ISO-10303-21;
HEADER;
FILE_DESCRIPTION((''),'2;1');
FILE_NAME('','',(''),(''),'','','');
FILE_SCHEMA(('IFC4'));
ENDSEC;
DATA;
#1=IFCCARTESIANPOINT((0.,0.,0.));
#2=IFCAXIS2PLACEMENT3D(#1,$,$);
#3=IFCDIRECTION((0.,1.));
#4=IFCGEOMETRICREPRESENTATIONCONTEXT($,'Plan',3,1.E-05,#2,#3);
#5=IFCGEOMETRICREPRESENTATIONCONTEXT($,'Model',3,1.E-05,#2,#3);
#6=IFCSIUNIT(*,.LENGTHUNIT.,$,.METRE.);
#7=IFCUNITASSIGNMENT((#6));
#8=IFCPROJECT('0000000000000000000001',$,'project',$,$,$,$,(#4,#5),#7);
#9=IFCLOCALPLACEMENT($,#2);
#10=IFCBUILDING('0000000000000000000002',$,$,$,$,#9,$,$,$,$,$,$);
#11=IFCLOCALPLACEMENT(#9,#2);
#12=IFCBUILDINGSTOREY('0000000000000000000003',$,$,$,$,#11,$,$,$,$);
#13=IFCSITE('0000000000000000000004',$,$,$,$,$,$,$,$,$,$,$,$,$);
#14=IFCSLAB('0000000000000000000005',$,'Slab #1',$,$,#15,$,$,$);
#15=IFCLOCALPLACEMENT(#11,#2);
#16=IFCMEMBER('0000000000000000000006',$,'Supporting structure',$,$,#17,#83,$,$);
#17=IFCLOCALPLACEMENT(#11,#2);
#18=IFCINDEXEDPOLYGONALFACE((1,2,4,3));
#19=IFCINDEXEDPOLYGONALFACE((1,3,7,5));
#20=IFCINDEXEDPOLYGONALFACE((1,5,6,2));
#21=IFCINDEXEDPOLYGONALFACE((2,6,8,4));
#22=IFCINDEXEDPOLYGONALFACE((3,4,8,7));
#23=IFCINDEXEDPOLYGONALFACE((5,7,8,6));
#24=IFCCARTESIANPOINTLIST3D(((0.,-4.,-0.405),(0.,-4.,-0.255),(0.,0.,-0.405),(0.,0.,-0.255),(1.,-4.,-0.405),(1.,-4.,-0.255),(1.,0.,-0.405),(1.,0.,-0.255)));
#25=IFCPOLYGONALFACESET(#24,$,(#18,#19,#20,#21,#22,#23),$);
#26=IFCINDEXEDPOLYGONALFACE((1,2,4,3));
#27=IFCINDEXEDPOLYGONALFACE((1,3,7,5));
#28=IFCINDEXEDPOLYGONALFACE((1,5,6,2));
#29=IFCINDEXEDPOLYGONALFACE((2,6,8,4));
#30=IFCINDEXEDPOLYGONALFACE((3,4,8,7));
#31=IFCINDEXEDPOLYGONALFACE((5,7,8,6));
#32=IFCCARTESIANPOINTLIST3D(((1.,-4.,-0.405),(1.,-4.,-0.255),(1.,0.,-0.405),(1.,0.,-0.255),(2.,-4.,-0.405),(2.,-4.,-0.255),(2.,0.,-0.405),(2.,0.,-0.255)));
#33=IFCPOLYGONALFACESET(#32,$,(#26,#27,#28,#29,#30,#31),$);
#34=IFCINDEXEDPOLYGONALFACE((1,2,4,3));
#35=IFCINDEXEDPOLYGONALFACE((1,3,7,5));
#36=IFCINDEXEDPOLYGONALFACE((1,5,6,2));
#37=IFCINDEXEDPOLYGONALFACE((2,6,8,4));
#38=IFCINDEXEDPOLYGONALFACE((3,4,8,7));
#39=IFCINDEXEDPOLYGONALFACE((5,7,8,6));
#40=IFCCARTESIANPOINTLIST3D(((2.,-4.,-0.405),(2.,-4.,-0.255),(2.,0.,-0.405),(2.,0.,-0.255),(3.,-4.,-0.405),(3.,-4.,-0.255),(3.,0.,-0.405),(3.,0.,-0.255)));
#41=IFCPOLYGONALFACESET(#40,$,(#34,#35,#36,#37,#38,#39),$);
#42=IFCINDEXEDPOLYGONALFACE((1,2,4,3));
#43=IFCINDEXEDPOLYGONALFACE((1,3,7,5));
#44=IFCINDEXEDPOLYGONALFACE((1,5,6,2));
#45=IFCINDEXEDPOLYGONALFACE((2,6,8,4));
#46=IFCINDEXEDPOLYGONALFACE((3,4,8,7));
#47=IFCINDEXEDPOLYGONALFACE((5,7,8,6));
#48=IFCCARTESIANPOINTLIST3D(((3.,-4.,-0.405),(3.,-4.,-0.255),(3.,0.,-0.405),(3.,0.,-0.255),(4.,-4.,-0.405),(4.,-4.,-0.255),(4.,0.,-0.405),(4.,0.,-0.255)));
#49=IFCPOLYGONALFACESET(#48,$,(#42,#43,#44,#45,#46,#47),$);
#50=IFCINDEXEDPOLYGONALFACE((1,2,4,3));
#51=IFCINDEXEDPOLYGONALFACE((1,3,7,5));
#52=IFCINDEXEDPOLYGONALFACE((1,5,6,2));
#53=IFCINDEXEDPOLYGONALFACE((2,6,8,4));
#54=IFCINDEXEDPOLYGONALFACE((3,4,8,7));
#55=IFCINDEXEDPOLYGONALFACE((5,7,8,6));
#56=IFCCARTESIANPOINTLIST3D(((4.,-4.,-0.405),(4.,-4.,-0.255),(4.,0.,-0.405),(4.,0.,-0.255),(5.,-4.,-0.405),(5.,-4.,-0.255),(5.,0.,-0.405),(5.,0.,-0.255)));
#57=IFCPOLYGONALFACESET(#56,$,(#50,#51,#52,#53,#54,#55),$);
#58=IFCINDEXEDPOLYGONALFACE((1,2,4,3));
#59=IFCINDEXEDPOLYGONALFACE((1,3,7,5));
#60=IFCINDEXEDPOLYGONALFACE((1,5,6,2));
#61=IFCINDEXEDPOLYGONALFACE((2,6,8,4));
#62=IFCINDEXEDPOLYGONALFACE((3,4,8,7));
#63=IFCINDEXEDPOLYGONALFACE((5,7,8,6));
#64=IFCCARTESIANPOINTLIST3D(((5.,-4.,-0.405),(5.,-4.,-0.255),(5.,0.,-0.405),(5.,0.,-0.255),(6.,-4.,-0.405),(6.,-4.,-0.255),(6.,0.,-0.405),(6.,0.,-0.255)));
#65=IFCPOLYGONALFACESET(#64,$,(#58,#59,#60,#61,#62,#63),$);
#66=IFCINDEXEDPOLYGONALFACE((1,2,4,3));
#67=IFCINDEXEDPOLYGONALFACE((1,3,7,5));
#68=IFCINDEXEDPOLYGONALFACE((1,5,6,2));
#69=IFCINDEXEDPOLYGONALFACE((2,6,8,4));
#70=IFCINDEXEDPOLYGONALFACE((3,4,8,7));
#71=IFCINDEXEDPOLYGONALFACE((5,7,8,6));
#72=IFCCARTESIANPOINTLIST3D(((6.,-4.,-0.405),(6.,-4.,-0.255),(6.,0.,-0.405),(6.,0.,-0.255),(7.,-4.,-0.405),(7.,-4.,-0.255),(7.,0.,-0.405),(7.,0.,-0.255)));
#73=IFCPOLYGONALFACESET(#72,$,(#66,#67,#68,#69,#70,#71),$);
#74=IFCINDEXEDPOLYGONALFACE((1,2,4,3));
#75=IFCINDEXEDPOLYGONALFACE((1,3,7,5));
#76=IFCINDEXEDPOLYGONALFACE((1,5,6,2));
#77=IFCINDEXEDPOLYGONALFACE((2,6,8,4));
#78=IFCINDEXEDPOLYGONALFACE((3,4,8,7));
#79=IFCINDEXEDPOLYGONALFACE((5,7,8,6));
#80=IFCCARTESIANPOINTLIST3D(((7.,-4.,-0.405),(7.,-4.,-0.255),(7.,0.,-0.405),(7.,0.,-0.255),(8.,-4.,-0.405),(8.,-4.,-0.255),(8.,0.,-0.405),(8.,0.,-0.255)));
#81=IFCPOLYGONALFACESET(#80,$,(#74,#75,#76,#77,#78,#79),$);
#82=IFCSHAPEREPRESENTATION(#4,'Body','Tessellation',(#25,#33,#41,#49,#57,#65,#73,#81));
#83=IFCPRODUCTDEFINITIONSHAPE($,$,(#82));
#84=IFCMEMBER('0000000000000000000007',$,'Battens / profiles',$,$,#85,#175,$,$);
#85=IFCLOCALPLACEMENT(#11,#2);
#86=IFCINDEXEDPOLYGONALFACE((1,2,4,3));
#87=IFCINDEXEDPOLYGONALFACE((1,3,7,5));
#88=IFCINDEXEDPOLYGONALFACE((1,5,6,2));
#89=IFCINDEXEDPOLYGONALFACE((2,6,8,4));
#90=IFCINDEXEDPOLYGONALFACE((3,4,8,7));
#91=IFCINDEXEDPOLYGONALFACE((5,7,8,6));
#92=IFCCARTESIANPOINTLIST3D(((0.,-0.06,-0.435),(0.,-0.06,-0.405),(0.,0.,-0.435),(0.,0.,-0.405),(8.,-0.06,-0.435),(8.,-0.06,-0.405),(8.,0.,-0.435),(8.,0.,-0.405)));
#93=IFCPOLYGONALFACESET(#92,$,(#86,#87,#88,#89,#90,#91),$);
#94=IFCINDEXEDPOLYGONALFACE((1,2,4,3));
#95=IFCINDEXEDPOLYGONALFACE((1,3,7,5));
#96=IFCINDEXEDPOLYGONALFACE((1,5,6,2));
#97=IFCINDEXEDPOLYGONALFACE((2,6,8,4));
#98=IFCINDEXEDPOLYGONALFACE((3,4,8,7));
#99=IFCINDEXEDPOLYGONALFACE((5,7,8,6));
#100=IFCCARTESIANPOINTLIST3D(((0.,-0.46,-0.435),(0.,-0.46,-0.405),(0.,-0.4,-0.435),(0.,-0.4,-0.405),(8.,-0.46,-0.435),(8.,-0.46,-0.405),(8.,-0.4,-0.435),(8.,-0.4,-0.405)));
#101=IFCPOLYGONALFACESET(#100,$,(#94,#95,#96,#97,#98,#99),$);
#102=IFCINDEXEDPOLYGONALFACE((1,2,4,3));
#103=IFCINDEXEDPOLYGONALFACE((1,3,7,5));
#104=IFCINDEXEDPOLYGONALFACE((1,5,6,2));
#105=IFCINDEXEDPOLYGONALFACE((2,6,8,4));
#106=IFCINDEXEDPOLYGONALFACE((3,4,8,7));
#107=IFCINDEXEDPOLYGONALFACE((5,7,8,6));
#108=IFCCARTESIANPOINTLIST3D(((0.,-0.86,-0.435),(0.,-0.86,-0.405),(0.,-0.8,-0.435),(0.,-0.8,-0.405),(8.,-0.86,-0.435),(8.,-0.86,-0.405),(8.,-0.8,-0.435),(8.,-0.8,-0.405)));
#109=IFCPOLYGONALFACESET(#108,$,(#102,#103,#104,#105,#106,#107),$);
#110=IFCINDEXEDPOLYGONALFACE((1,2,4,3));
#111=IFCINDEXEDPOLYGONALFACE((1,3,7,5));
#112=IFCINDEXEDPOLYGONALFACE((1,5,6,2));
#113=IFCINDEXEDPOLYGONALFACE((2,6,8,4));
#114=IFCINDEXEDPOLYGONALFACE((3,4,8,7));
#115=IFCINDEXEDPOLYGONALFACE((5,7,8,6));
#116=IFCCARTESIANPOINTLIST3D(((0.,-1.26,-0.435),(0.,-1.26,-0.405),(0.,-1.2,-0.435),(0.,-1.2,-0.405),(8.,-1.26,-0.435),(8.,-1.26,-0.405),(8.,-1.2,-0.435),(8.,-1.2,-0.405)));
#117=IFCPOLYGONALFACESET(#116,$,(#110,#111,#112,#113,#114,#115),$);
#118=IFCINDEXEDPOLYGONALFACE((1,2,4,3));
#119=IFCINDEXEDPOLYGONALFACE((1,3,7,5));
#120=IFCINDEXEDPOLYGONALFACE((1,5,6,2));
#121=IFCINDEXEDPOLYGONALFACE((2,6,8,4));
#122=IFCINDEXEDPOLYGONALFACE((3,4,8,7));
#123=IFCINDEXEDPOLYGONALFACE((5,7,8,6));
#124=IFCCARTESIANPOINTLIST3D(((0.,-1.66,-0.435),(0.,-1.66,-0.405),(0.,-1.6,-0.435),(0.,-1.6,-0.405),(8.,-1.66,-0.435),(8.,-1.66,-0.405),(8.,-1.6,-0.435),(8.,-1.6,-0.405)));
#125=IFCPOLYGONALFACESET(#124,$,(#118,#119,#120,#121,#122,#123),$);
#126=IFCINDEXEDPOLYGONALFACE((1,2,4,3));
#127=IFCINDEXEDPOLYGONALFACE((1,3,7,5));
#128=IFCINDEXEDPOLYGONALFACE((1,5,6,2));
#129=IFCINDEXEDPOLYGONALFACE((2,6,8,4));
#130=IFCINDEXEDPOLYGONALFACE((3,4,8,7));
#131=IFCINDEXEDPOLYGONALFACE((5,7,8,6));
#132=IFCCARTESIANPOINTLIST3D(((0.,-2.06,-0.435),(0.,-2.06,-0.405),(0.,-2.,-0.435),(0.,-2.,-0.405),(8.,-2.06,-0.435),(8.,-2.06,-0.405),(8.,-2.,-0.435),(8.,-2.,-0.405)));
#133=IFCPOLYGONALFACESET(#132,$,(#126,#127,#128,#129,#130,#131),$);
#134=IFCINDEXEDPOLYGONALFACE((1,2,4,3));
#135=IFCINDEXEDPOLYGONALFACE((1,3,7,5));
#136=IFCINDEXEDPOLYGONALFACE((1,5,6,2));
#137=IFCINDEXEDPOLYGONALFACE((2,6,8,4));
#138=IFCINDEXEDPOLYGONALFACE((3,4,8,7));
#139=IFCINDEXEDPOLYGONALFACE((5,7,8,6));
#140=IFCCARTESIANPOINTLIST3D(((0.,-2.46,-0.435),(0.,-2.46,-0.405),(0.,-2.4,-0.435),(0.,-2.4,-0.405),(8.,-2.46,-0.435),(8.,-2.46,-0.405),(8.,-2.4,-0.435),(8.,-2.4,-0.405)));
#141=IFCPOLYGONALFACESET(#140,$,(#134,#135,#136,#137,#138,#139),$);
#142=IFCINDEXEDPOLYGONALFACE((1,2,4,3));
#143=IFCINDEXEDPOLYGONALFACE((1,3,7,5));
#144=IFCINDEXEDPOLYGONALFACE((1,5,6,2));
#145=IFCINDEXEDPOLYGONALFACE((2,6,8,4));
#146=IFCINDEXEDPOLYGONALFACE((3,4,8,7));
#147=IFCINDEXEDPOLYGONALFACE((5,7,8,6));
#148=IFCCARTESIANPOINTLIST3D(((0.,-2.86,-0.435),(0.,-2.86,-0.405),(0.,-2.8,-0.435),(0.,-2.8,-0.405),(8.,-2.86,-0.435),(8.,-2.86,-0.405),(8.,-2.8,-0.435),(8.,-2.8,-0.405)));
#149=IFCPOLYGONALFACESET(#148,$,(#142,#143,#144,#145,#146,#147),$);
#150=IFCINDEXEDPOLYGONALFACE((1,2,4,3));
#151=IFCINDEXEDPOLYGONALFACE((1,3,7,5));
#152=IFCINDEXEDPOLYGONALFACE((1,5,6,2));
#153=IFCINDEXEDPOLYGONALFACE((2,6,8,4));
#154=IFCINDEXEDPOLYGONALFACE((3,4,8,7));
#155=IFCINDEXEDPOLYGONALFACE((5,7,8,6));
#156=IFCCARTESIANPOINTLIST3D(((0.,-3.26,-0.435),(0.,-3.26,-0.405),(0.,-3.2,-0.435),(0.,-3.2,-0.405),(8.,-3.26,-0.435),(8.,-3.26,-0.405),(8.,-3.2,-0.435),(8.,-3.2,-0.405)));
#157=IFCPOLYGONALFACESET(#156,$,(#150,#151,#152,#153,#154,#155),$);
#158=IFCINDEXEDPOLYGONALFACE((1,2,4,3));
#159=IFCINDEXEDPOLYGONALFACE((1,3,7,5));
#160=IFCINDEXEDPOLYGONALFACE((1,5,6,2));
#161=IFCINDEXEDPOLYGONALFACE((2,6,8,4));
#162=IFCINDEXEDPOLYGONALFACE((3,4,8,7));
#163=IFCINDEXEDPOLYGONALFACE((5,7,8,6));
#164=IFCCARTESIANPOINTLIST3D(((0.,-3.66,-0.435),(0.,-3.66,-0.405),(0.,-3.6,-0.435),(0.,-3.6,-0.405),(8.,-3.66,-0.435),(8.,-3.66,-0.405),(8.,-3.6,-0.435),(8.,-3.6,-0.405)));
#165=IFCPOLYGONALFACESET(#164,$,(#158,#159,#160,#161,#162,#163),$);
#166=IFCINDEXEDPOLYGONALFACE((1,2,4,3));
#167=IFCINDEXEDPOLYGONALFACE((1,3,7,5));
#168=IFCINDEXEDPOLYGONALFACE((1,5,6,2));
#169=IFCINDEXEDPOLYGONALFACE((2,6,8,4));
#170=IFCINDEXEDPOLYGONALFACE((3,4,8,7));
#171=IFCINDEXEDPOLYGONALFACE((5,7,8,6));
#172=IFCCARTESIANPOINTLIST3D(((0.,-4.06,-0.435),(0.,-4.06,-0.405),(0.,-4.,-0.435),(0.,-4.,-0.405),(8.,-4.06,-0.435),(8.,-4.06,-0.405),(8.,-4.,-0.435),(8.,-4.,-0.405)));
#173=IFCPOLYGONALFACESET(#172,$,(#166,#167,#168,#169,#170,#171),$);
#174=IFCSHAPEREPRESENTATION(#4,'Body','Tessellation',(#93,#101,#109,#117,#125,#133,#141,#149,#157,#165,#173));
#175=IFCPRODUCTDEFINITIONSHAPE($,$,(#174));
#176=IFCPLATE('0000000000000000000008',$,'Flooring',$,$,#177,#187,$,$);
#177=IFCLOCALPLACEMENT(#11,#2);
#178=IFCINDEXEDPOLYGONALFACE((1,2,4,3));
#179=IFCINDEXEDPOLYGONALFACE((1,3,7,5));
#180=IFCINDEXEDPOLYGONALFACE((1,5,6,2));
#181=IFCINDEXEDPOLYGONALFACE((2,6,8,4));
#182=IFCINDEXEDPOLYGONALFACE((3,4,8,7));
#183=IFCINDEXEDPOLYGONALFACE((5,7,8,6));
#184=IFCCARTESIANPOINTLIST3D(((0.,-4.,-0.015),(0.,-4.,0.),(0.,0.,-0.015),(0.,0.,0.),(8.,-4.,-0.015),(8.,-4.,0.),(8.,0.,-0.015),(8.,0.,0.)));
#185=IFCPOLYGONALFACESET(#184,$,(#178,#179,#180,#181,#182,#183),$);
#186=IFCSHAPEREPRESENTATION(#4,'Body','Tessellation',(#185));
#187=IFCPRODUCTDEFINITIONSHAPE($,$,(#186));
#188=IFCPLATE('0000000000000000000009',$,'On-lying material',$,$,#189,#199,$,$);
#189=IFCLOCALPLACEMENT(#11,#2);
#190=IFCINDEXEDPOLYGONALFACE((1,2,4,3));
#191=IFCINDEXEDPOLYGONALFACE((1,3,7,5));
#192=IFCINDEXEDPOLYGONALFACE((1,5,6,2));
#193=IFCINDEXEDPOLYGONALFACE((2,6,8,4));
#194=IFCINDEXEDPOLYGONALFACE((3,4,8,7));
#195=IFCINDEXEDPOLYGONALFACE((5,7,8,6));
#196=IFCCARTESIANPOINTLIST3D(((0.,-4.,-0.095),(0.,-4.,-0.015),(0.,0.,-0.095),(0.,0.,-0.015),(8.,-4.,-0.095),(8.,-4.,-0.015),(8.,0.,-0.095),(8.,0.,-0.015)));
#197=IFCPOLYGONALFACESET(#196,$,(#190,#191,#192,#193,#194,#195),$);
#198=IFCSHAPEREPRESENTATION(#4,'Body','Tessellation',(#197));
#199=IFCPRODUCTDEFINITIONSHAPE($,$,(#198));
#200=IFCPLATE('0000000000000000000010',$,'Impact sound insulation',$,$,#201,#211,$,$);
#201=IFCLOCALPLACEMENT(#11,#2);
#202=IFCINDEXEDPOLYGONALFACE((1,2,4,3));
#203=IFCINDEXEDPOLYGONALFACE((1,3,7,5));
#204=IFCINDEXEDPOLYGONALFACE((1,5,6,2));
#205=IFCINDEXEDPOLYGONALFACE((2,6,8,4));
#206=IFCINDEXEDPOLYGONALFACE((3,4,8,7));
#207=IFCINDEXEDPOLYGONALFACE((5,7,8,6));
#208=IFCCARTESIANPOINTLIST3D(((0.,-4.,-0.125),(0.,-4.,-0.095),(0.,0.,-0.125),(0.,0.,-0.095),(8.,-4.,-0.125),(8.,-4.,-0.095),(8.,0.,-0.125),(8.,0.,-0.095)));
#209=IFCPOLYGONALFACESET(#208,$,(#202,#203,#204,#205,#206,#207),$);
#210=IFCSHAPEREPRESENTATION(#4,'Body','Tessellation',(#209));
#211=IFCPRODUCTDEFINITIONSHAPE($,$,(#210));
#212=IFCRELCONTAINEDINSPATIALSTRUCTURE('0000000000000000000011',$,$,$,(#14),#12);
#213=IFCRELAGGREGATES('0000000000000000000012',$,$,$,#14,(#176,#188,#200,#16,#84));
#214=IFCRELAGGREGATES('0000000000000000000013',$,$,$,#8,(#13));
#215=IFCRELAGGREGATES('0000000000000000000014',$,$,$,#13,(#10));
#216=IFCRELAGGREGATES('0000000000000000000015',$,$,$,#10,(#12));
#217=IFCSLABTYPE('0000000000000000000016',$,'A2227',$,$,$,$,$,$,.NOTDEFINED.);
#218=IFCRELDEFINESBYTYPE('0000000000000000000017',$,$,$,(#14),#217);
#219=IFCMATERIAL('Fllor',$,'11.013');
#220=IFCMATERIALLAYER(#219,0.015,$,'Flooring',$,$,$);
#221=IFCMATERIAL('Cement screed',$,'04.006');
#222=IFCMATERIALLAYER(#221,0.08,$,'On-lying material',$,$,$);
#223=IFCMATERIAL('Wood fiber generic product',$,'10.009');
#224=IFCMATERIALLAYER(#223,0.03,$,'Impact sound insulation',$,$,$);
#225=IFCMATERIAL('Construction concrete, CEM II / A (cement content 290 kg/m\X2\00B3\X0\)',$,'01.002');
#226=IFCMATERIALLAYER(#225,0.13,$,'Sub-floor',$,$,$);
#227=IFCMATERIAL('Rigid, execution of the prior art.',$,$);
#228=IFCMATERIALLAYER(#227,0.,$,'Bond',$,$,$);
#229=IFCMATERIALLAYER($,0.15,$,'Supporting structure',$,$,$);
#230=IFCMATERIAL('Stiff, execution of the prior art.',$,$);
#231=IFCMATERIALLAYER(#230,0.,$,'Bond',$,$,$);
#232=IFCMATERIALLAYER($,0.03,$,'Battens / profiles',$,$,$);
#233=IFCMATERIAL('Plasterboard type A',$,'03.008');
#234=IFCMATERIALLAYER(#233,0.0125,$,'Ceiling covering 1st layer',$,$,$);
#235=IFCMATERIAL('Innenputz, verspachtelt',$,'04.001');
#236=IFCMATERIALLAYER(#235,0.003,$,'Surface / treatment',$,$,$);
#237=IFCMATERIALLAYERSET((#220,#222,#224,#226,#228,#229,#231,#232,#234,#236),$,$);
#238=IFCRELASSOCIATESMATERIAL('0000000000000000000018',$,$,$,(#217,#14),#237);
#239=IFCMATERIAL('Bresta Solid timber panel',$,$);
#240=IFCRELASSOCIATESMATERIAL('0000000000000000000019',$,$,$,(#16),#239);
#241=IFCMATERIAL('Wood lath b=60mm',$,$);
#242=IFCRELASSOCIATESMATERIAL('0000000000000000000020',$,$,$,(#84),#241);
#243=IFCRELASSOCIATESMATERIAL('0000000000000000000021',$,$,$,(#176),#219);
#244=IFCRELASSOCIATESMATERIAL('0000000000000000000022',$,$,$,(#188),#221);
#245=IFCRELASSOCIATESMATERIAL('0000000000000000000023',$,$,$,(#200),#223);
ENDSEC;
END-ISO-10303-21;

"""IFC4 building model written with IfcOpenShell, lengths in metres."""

from ifc_helpers import new_model, si_unit, direction, frame, frame_2d, origin, origin_with_axes, place, context, project, spatial, rectangle, extrude, material, layer, layer_set, type_object, element, aggregate, save


model = new_model("IFC4")

# Units and contexts
plan_context = context("Plan", 3, precision=1e-05, world=origin(), true_north=direction((0.0, 1.0)))
model_context = context("Model", 3, precision=1e-05, world=origin(), true_north=direction((0.0, 1.0)))
ifc_project = project(units=[si_unit("LENGTHUNIT", "METRE")], contexts=[plan_context, model_context])

# Site, building, storey
site = spatial("IfcSite", under=ifc_project)
building_placement = place(None, origin())
building = spatial("IfcBuilding", under=site, at=building_placement)
storey_placement = place(building_placement, origin())
storey = spatial("IfcBuildingStorey", under=building, at=storey_placement)

# Slab, members, plates
ifc_material_1 = material(Name="Fllor", Category="11.013")
ifc_layer_1 = layer(ifc_material_1, 0.015, Name="Flooring")
ifc_material_2 = material(Name="Cement screed", Category="04.006")
ifc_layer_2 = layer(ifc_material_2, 0.08, Name="On-lying material")
ifc_material_3 = material(Name="Wood fiber generic product", Category="10.009")
ifc_layer_3 = layer(ifc_material_3, 0.03, Name="Impact sound insulation")
ifc_material_4 = material(Name="Construction concrete, CEM II / A (cement content 290 kg/m³)", Category="01.002")
ifc_layer_4 = layer(ifc_material_4, 0.13, Name="Sub-floor")
ifc_material_5 = material(Name="Rigid, execution of the prior art.")
ifc_layer_5 = layer(ifc_material_5, 0.0, Name="Bond")
ifc_layer_6 = layer(None, 0.15, Name="Supporting structure")
ifc_material_6 = material(Name="Stiff, execution of the prior art.")
ifc_layer_7 = layer(ifc_material_6, 0.0, Name="Bond")
ifc_layer_8 = layer(None, 0.03, Name="Battens / profiles")
ifc_material_7 = material(Name="Plasterboard type A", Category="03.008")
ifc_layer_9 = layer(ifc_material_7, 0.0125, Name="Ceiling covering 1st layer")
ifc_material_8 = material(Name="Innenputz, verspachtelt", Category="04.001")
ifc_layer_10 = layer(ifc_material_8, 0.003, Name="Surface / treatment")
ifc_layer_set = layer_set([ifc_layer_1, ifc_layer_2, ifc_layer_3, ifc_layer_4, ifc_layer_5, ifc_layer_6, ifc_layer_7, ifc_layer_8, ifc_layer_9, ifc_layer_10])
slab_type = type_object("IfcSlabType", Name="A2227", PredefinedType="NOTDEFINED", material=ifc_layer_set)
slab_placement = place(None, frame((0.0, 0.0, 0.0), z_axis=(0.0, 0.0, -1.0), x_axis=(1.0, 0.0, 0.0)))
slab = element("IfcSlab", 1, at=slab_placement, inside=storey, type_object=slab_type, material=ifc_layer_set, Name="Slab #1")
ifc_material_9 = material(Name="Bresta Solid timber panel")
member_1_placement = place(slab_placement, origin())
member_1 = element("IfcMember", 2, at=member_1_placement, material=ifc_material_9, Name="Supporting structure", context=plan_context, shape_type="SweptSolid", body=[
    extrude(rectangle(XDim=1.0, YDim=0.15, at=frame_2d((0.5, 0.075), x_axis=(1.0, 0.0))), frame((0.0, 4.0, 0.255), z_axis=(0.0, -1.0, 0.0), x_axis=(1.0, 0.0, 0.0)), (0.0, 0.0, 1.0), 4.0),
    extrude(rectangle(XDim=1.0, YDim=0.15, at=frame_2d((0.5, 0.075), x_axis=(1.0, 0.0))), frame((1.0, 4.0, 0.255), z_axis=(0.0, -1.0, 0.0), x_axis=(1.0, 0.0, 0.0)), (0.0, 0.0, 1.0), 4.0),
    extrude(rectangle(XDim=1.0, YDim=0.15, at=frame_2d((0.5, 0.075), x_axis=(1.0, 0.0))), frame((2.0, 4.0, 0.255), z_axis=(0.0, -1.0, 0.0), x_axis=(1.0, 0.0, 0.0)), (0.0, 0.0, 1.0), 4.0),
    extrude(rectangle(XDim=1.0, YDim=0.15, at=frame_2d((0.5, 0.075), x_axis=(1.0, 0.0))), frame((3.0, 4.0, 0.255), z_axis=(0.0, -1.0, 0.0), x_axis=(1.0, 0.0, 0.0)), (0.0, 0.0, 1.0), 4.0),
    extrude(rectangle(XDim=1.0, YDim=0.15, at=frame_2d((0.5, 0.075), x_axis=(1.0, 0.0))), frame((4.0, 4.0, 0.255), z_axis=(0.0, -1.0, 0.0), x_axis=(1.0, 0.0, 0.0)), (0.0, 0.0, 1.0), 4.0),
    extrude(rectangle(XDim=1.0, YDim=0.15, at=frame_2d((0.5, 0.075), x_axis=(1.0, 0.0))), frame((5.0, 4.0, 0.255), z_axis=(0.0, -1.0, 0.0), x_axis=(1.0, 0.0, 0.0)), (0.0, 0.0, 1.0), 4.0),
    extrude(rectangle(XDim=1.0, YDim=0.15, at=frame_2d((0.5, 0.075), x_axis=(1.0, 0.0))), frame((6.0, 4.0, 0.255), z_axis=(0.0, -1.0, 0.0), x_axis=(1.0, 0.0, 0.0)), (0.0, 0.0, 1.0), 4.0),
    extrude(rectangle(XDim=1.0, YDim=0.15, at=frame_2d((0.5, 0.075), x_axis=(1.0, 0.0))), frame((7.0, 4.0, 0.255), z_axis=(0.0, -1.0, 0.0), x_axis=(1.0, 0.0, 0.0)), (0.0, 0.0, 1.0), 4.0),
])
ifc_material_10 = material(Name="Wood lath b=60mm")
member_2_placement = place(slab_placement, origin())
member_2 = element("IfcMember", 3, at=member_2_placement, material=ifc_material_10, Name="Battens / profiles", context=plan_context, shape_type="SweptSolid", body=[
    extrude(rectangle(XDim=0.06, YDim=0.03, at=frame_2d((0.03, 0.015), x_axis=(1.0, 0.0))), frame((0.0, 0.0, 0.405), z_axis=(1.0, 0.0, 0.0), x_axis=(0.0, 1.0, 0.0)), (0.0, 0.0, 1.0), 8.0),
    extrude(rectangle(XDim=0.06, YDim=0.03, at=frame_2d((0.03, 0.015), x_axis=(1.0, 0.0))), frame((0.0, 0.4, 0.405), z_axis=(1.0, 0.0, 0.0), x_axis=(0.0, 1.0, 0.0)), (0.0, 0.0, 1.0), 8.0),
    extrude(rectangle(XDim=0.06, YDim=0.03, at=frame_2d((0.03, 0.015), x_axis=(1.0, 0.0))), frame((0.0, 0.8, 0.405), z_axis=(1.0, 0.0, 0.0), x_axis=(0.0, 1.0, 0.0)), (0.0, 0.0, 1.0), 8.0),
    extrude(rectangle(XDim=0.06, YDim=0.03, at=frame_2d((0.03, 0.015), x_axis=(1.0, 0.0))), frame((0.0, 1.2, 0.405), z_axis=(1.0, 0.0, 0.0), x_axis=(0.0, 1.0, 0.0)), (0.0, 0.0, 1.0), 8.0),
    extrude(rectangle(XDim=0.06, YDim=0.03, at=frame_2d((0.03, 0.015), x_axis=(1.0, 0.0))), frame((0.0, 1.6, 0.405), z_axis=(1.0, 0.0, 0.0), x_axis=(0.0, 1.0, 0.0)), (0.0, 0.0, 1.0), 8.0),
    extrude(rectangle(XDim=0.06, YDim=0.03, at=frame_2d((0.03, 0.015), x_axis=(1.0, 0.0))), frame((0.0, 2.0, 0.405), z_axis=(1.0, 0.0, 0.0), x_axis=(0.0, 1.0, 0.0)), (0.0, 0.0, 1.0), 8.0),
    extrude(rectangle(XDim=0.06, YDim=0.03, at=frame_2d((0.03, 0.015), x_axis=(1.0, 0.0))), frame((0.0, 2.4, 0.405), z_axis=(1.0, 0.0, 0.0), x_axis=(0.0, 1.0, 0.0)), (0.0, 0.0, 1.0), 8.0),
    extrude(rectangle(XDim=0.06, YDim=0.03, at=frame_2d((0.03, 0.015), x_axis=(1.0, 0.0))), frame((0.0, 2.8, 0.405), z_axis=(1.0, 0.0, 0.0), x_axis=(0.0, 1.0, 0.0)), (0.0, 0.0, 1.0), 8.0),
    extrude(rectangle(XDim=0.06, YDim=0.03, at=frame_2d((0.03, 0.015), x_axis=(1.0, 0.0))), frame((0.0, 3.2, 0.405), z_axis=(1.0, 0.0, 0.0), x_axis=(0.0, 1.0, 0.0)), (0.0, 0.0, 1.0), 8.0),
    extrude(rectangle(XDim=0.06, YDim=0.03, at=frame_2d((0.03, 0.015), x_axis=(1.0, 0.0))), frame((0.0, 3.6, 0.405), z_axis=(1.0, 0.0, 0.0), x_axis=(0.0, 1.0, 0.0)), (0.0, 0.0, 1.0), 8.0),
    extrude(rectangle(XDim=0.06, YDim=0.03, at=frame_2d((0.03, 0.015), x_axis=(1.0, 0.0))), frame((0.0, 4.0, 0.405), z_axis=(1.0, 0.0, 0.0), x_axis=(0.0, 1.0, 0.0)), (0.0, 0.0, 1.0), 8.0),
])
plate_1_placement = place(slab_placement, origin())
plate_1 = element("IfcPlate", 4, at=plate_1_placement, material=ifc_material_1, Name="Flooring", context=plan_context, shape_type="SweptSolid", body=[
    extrude(rectangle(XDim=8.0, YDim=4.0, at=frame_2d((4.0, 2.0), x_axis=(1.0, 0.0))), origin_with_axes(), (0.0, 0.0, 1.0), 0.015),
])
plate_2_placement = place(slab_placement, origin())
plate_2 = element("IfcPlate", 5, at=plate_2_placement, material=ifc_material_2, Name="On-lying material", context=plan_context, shape_type="SweptSolid", body=[
    extrude(rectangle(XDim=8.0, YDim=4.0, at=frame_2d((4.0, 2.0), x_axis=(1.0, 0.0))), frame((0.0, 0.0, 0.015), z_axis=(0.0, 0.0, 1.0), x_axis=(1.0, 0.0, 0.0)), (0.0, 0.0, 1.0), 0.08),
])
plate_3_placement = place(slab_placement, origin())
plate_3 = element("IfcPlate", 6, at=plate_3_placement, material=ifc_material_3, Name="Impact sound insulation", context=plan_context, shape_type="SweptSolid", body=[
    extrude(rectangle(XDim=8.0, YDim=4.0, at=frame_2d((4.0, 2.0), x_axis=(1.0, 0.0))), frame((0.0, 0.0, 0.095), z_axis=(0.0, 0.0, 1.0), x_axis=(1.0, 0.0, 0.0)), (0.0, 0.0, 1.0), 0.03),
])
aggregate(slab, [plate_1, plate_2, plate_3, member_1, member_2])

save(model, "model.ifc")
